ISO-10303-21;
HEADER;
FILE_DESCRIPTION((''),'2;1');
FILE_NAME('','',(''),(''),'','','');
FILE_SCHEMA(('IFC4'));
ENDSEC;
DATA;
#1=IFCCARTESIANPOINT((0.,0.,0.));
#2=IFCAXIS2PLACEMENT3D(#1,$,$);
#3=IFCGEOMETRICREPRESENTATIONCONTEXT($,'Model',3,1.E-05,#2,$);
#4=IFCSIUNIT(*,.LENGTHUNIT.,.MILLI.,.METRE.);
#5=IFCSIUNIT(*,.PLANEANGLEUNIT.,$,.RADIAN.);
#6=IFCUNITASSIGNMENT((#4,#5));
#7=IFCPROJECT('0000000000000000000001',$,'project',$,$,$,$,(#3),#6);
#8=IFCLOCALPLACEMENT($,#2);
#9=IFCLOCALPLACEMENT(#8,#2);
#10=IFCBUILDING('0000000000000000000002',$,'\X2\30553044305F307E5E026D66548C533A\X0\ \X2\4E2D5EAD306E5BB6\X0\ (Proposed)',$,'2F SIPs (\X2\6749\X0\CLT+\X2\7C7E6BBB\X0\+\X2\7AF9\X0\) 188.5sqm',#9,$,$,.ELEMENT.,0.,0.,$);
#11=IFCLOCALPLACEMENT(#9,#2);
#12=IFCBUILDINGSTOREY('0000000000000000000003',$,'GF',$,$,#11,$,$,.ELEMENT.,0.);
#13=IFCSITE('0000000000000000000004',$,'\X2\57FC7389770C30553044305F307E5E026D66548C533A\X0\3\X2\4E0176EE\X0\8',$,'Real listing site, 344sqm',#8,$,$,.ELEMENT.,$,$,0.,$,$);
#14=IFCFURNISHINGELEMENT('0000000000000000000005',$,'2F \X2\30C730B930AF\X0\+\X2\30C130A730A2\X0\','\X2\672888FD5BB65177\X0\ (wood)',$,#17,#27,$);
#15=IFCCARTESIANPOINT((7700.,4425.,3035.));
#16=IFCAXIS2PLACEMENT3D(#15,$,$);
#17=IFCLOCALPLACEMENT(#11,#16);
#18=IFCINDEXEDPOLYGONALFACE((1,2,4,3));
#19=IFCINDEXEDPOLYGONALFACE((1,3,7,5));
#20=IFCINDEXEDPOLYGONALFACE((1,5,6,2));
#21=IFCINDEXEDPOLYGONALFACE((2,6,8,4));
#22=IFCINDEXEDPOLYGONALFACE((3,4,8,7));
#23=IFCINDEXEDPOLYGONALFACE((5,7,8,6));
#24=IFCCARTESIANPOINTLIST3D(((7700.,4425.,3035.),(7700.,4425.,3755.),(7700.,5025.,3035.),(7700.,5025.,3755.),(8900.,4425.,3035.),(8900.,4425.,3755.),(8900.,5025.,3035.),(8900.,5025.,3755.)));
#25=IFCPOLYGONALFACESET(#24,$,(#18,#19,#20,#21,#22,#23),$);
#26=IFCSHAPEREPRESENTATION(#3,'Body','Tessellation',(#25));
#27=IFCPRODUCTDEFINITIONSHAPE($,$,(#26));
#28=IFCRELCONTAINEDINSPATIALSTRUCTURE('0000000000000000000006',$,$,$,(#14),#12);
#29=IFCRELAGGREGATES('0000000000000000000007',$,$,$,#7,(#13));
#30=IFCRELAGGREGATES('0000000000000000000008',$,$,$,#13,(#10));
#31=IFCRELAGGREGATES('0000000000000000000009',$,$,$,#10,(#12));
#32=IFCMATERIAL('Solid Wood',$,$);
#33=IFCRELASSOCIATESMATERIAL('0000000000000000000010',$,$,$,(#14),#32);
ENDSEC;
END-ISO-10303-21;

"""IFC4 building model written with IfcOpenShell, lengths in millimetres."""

from ifc_helpers import new_model, si_unit, frame, frame_2d, origin, place, context, project, spatial, rectangle, extrude, material, element, save


model = new_model("IFC4")

# Units and contexts
model_context = context("Model", 3, precision=1e-05, world=origin())
ifc_project = project(units=[si_unit("LENGTHUNIT", "METRE", prefix="MILLI"), si_unit("PLANEANGLEUNIT", "RADIAN")], contexts=[model_context])

# Site, building, storey
site_placement = place(None, origin())
site = spatial("IfcSite", under=ifc_project, at=site_placement, Name="埼玉県さいたま市浦和区3丁目8", ObjectType="Real listing site, 344sqm", CompositionType="ELEMENT", RefElevation=0.0)
building_placement = place(site_placement, origin())
building = spatial("IfcBuilding", under=site, at=building_placement, Name="さいたま市浦和区 中庭の家 (Proposed)", ObjectType="2F SIPs (杉CLT+籾殻+竹) 188.5sqm", CompositionType="ELEMENT", ElevationOfRefHeight=0.0, ElevationOfTerrain=0.0)
storey_placement = place(building_placement, origin())
storey = spatial("IfcBuildingStorey", under=building, at=storey_placement, Name="GF", CompositionType="ELEMENT", Elevation=0.0)

# Shared definitions
ifc_material_1 = material(Name="Solid Wood")

# Furnishing element
furnishing_1_placement = place(storey_placement, frame((7700.0, 4425.0, 3035.0)))
element("IfcFurnishingElement", 1, at=furnishing_1_placement, inside=storey, material=ifc_material_1, Name="2F デスク+チェア", Description="木製家具 (wood)", context=model_context, shape_type="SweptSolid", body=[
    extrude(rectangle(XDim=1200.0, YDim=600.0, at=frame_2d((600.0, 300.0))), frame((7700.0, 4425.0, 3035.0)), (0.0, 0.0, 1.0), 720.0),
])

save(model, "model.ifc")
